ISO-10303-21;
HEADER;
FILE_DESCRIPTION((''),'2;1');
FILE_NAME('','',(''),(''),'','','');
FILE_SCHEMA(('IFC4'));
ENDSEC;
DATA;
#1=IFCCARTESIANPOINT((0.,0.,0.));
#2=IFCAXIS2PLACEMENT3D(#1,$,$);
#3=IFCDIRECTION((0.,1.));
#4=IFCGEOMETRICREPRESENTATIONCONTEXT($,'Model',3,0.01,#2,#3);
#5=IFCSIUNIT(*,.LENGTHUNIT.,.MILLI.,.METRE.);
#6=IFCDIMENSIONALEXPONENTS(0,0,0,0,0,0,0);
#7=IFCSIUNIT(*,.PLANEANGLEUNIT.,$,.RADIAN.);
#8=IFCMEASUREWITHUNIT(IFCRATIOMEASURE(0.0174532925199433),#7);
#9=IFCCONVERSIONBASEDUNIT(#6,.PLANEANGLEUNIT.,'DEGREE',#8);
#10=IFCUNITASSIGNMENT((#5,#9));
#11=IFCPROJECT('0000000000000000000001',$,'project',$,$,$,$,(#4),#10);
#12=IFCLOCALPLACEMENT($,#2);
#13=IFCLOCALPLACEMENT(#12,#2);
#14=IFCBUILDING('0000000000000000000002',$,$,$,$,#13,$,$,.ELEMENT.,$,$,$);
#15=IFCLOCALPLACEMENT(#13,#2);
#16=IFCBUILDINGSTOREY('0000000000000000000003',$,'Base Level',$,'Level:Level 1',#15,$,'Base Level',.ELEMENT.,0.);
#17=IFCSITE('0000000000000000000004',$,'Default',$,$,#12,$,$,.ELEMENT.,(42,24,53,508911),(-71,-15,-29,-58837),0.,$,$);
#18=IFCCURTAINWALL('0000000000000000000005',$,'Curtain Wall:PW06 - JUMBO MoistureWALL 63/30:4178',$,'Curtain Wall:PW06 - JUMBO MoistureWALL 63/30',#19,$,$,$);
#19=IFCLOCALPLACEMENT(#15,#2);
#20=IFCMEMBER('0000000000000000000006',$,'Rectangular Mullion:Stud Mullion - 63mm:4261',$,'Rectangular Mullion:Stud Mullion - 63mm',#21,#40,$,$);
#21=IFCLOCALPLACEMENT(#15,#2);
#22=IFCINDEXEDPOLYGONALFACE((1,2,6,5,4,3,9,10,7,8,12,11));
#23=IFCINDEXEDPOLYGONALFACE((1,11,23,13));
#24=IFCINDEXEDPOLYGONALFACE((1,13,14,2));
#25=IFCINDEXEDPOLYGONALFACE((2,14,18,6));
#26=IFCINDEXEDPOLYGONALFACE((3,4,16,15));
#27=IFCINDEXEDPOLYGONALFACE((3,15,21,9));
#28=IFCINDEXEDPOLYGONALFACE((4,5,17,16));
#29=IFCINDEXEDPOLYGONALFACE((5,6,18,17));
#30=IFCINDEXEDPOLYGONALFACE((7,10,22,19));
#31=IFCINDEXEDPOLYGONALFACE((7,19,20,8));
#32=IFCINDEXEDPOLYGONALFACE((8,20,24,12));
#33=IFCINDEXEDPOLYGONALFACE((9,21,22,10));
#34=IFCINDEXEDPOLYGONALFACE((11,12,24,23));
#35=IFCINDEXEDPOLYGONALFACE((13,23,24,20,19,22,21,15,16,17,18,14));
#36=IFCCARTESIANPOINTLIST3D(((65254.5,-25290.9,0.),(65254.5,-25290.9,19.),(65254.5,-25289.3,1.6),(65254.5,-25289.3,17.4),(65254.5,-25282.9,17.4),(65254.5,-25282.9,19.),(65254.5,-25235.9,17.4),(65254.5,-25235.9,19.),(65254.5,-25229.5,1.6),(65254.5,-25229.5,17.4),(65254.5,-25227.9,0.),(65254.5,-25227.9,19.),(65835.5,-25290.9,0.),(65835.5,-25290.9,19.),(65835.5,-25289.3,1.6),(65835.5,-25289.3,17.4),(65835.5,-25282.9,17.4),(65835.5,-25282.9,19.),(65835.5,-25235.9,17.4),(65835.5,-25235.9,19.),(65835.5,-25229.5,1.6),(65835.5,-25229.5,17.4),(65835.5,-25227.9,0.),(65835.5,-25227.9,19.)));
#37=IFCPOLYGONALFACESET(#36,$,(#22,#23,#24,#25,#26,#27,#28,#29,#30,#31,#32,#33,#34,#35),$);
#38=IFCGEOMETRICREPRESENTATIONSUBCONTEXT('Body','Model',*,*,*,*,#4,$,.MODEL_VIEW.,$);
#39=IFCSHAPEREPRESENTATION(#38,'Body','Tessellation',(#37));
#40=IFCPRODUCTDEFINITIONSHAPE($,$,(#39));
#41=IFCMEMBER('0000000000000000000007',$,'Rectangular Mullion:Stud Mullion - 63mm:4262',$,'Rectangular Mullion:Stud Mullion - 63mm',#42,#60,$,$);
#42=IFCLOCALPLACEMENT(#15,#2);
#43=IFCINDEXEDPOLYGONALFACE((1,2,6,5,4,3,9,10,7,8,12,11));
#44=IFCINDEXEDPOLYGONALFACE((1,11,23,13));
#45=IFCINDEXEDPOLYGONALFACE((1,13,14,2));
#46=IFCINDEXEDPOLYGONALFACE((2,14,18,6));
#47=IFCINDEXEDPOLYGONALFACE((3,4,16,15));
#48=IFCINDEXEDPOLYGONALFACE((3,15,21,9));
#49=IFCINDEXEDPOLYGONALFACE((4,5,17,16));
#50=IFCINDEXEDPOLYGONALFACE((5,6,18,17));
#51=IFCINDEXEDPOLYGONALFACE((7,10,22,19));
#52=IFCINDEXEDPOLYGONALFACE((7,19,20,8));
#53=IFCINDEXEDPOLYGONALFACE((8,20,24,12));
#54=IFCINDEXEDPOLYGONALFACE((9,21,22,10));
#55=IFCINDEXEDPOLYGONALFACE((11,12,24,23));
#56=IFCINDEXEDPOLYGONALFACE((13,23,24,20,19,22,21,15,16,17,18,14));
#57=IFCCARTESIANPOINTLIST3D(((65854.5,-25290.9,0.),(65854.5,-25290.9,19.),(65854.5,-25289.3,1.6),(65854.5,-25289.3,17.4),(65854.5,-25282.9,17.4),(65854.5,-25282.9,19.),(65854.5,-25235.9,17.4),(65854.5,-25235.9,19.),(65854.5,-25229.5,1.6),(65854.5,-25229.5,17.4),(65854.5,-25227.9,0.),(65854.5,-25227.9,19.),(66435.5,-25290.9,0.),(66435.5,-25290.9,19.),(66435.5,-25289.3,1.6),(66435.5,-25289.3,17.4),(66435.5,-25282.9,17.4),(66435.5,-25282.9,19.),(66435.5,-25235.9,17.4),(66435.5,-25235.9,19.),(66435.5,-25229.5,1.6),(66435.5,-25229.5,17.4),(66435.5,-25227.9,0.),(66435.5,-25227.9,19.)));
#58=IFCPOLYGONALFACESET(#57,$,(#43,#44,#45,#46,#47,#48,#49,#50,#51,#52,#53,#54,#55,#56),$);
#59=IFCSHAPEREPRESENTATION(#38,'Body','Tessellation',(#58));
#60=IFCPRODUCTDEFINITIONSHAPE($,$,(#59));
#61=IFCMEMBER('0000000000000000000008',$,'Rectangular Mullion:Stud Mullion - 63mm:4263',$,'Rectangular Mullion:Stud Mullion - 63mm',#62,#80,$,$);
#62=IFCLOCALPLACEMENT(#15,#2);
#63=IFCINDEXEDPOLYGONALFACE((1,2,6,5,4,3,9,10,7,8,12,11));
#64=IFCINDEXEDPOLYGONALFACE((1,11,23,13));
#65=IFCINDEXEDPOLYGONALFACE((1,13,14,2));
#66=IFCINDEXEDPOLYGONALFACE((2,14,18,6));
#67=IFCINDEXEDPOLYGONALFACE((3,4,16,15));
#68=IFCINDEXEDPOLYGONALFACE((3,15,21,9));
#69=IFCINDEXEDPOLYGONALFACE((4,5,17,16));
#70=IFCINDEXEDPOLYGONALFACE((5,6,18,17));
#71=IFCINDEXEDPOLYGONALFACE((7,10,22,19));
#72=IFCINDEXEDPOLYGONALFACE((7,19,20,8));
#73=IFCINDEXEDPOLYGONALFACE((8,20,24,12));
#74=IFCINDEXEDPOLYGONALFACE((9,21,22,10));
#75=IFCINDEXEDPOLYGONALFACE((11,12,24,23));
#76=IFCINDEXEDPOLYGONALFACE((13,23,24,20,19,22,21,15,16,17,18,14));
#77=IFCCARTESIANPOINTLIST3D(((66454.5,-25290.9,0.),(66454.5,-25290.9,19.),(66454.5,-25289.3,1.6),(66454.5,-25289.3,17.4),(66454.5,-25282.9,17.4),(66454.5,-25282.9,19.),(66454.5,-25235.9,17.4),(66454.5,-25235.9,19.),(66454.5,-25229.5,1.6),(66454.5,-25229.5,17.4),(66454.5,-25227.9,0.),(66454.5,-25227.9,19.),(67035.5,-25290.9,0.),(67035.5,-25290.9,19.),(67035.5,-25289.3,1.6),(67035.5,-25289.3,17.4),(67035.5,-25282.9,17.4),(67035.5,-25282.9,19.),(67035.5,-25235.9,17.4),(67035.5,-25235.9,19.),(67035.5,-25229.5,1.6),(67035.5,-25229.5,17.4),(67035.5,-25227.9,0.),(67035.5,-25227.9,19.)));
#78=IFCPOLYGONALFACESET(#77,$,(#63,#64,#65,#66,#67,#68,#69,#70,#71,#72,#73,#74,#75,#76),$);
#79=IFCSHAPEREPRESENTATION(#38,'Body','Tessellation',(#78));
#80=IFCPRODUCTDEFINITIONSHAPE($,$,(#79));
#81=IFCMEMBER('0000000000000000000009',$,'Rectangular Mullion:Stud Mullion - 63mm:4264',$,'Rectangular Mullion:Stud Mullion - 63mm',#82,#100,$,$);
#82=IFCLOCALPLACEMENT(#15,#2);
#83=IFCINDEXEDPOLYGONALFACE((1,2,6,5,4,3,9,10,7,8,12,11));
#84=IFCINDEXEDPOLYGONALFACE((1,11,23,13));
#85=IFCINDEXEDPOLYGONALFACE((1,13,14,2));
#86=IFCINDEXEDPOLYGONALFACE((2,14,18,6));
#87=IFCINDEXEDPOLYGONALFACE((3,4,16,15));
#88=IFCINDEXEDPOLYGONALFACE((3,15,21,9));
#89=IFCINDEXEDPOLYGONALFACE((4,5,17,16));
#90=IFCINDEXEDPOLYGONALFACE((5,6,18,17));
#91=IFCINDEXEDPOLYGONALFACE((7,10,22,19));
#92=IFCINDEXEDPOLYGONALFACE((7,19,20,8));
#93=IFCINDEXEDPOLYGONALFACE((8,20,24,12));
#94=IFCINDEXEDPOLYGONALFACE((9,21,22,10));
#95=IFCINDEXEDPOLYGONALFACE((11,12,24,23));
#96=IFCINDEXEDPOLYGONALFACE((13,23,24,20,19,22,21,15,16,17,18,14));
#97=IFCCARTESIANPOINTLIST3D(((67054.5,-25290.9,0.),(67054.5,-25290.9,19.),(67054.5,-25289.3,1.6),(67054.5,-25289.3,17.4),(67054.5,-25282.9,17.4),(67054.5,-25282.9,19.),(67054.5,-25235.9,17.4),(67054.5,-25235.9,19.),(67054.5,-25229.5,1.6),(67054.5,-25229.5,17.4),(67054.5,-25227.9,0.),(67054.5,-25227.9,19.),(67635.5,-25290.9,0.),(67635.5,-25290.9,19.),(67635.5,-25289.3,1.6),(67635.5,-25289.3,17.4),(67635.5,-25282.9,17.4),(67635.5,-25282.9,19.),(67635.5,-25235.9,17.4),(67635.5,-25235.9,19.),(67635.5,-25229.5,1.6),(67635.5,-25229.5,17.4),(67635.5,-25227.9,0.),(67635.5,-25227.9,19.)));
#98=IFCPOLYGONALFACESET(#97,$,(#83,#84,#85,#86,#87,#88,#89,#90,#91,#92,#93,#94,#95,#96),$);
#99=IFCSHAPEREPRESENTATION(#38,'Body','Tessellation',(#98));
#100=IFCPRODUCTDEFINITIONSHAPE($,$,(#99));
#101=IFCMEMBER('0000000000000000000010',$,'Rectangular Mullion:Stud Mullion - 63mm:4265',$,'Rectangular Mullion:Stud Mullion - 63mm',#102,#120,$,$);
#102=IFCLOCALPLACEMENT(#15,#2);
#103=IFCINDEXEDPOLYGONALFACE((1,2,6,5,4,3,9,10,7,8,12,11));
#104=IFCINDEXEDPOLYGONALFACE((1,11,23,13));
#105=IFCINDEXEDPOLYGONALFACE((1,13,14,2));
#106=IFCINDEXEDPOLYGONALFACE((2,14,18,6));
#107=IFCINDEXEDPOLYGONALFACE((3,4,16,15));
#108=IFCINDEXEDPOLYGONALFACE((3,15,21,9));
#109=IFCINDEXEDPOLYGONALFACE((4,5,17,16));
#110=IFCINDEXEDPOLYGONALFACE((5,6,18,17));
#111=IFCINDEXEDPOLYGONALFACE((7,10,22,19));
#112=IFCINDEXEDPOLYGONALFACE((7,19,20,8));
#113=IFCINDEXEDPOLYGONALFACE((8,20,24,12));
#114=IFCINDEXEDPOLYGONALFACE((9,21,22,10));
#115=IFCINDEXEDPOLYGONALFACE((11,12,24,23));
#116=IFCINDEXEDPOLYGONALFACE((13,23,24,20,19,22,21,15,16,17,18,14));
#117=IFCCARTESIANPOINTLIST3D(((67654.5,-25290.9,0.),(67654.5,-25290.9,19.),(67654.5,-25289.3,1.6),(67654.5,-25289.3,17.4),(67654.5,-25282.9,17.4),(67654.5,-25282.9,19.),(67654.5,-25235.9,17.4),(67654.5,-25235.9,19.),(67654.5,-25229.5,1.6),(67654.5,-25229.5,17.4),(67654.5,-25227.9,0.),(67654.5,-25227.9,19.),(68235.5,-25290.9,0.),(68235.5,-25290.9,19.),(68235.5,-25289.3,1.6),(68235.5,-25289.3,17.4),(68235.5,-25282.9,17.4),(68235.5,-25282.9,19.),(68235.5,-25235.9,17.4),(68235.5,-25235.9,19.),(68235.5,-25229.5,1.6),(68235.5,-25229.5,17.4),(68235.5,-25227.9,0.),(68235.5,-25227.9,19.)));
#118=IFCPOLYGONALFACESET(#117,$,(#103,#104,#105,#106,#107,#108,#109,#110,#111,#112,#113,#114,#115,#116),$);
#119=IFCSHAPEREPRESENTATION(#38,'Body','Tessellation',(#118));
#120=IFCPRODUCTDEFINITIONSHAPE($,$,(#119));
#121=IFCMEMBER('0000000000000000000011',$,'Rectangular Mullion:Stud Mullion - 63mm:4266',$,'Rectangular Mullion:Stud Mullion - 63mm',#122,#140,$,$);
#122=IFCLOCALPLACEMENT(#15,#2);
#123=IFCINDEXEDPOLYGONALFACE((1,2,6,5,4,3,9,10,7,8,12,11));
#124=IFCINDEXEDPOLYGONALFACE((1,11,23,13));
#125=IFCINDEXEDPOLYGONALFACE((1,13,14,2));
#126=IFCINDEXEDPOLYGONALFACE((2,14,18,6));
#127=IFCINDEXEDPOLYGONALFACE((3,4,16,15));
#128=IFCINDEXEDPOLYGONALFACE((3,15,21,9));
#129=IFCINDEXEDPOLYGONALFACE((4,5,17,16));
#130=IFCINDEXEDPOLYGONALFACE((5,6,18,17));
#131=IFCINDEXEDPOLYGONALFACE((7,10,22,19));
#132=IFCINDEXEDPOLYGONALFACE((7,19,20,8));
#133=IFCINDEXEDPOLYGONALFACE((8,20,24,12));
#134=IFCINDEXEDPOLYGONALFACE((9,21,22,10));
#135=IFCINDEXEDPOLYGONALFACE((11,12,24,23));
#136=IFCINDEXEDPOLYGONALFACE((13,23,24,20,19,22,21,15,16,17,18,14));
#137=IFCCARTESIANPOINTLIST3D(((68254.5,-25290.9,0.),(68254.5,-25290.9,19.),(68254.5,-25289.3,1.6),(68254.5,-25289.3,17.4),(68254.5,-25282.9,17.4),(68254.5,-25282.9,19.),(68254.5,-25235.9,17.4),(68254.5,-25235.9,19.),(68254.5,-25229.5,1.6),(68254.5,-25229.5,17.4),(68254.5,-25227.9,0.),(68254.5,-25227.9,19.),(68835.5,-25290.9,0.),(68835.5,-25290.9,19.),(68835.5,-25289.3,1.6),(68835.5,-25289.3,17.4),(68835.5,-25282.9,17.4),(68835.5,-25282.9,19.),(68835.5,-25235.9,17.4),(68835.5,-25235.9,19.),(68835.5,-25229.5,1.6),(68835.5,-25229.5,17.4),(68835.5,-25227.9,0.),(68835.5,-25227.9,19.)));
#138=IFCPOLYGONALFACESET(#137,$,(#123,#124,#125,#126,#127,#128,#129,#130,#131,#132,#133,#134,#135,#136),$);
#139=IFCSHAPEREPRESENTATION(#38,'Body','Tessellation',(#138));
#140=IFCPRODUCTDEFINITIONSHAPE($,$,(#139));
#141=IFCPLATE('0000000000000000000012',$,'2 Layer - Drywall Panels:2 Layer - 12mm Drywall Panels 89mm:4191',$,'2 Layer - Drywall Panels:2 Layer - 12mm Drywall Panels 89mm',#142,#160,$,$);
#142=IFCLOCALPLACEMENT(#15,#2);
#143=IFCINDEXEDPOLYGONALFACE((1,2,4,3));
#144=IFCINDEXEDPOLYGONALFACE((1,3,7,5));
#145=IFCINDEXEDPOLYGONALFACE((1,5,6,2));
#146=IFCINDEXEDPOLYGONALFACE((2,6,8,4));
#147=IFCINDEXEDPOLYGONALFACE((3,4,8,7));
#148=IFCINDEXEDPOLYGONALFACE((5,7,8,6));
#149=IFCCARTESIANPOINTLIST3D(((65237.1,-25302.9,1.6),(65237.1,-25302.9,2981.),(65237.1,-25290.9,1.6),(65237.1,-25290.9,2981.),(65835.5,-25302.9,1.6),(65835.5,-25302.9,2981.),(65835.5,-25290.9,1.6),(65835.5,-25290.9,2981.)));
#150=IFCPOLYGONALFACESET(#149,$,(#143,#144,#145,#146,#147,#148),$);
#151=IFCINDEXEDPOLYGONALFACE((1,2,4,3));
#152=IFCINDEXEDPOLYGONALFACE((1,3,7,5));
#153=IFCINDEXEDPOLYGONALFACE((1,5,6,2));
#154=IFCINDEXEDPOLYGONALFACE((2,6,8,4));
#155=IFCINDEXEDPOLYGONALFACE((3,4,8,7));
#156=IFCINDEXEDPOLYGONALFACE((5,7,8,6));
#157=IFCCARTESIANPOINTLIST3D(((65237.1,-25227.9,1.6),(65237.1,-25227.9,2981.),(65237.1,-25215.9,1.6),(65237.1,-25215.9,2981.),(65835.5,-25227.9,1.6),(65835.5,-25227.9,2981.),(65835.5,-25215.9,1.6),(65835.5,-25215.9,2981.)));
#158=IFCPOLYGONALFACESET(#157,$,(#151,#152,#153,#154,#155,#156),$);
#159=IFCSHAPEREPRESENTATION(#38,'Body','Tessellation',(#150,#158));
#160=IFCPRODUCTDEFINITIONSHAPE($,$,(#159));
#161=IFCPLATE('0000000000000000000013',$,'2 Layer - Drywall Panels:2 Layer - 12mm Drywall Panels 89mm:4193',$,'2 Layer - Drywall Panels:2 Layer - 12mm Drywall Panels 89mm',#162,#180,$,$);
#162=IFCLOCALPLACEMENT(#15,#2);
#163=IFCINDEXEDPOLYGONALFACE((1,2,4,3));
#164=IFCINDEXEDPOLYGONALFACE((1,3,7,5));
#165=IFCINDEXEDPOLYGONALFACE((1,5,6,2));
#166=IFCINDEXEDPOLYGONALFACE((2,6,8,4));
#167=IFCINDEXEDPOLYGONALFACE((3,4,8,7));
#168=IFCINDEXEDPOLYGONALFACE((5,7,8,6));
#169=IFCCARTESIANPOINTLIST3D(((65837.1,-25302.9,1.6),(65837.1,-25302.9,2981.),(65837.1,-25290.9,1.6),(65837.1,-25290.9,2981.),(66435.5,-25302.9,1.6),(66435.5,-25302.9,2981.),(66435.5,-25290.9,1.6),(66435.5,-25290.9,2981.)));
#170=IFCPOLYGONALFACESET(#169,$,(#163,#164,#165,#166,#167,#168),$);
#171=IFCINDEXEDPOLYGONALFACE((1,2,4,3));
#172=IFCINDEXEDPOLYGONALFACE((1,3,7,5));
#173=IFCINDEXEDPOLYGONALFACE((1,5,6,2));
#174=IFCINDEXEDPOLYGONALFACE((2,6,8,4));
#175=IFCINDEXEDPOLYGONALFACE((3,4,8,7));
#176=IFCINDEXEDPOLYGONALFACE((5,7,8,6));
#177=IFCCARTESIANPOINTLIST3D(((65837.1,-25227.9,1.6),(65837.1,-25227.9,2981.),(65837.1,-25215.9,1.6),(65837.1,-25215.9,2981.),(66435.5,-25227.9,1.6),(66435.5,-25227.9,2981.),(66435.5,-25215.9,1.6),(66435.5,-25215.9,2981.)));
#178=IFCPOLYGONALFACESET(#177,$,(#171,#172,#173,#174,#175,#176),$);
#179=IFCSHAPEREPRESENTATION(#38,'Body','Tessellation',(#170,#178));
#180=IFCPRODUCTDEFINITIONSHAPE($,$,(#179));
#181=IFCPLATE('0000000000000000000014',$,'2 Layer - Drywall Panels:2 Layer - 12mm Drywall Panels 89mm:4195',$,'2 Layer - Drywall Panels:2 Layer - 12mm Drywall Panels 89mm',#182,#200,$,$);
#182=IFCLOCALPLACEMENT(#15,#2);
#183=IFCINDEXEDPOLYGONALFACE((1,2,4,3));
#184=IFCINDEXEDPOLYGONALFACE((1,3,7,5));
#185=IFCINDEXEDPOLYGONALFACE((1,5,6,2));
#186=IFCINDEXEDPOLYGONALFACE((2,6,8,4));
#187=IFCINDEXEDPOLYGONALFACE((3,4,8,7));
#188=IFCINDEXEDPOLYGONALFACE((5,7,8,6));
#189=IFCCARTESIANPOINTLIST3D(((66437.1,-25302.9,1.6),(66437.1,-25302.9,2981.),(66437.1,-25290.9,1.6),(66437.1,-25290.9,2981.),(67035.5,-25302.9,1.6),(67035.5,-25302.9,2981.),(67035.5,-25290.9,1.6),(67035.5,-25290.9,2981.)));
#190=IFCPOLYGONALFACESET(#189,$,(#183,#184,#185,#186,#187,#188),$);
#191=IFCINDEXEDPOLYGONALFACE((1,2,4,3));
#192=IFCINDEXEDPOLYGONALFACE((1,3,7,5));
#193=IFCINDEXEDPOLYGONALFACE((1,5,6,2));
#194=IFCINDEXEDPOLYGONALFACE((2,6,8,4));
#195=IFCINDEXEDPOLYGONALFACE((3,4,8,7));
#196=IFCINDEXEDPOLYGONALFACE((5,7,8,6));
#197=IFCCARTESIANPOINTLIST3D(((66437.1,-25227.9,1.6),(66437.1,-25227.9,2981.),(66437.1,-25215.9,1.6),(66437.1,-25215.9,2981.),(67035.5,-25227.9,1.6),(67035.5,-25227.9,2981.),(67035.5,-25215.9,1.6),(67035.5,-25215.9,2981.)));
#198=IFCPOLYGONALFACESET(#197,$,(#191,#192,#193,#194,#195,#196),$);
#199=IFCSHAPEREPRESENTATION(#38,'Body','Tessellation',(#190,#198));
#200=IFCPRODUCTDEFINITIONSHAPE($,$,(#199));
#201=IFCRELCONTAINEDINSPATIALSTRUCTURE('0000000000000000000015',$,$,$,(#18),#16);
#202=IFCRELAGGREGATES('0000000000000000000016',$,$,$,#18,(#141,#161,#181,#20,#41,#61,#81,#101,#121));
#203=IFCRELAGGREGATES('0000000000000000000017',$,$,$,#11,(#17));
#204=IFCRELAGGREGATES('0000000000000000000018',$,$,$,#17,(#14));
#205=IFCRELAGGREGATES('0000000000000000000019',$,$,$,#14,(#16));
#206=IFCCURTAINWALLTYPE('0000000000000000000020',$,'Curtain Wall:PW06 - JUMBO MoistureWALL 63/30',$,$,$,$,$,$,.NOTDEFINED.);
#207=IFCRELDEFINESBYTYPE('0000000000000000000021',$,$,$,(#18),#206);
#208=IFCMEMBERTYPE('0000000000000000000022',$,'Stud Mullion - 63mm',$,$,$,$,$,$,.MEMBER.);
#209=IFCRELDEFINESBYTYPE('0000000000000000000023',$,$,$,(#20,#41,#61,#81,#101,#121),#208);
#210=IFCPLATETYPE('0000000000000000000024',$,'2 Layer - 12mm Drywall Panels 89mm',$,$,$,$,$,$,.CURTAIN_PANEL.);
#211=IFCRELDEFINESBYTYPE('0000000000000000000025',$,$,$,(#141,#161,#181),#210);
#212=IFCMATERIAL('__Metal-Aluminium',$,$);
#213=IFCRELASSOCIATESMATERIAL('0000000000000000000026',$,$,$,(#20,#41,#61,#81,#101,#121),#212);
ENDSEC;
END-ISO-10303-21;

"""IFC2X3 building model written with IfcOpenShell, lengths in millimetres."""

from ifc_helpers import new_model, entity, si_unit, converted_unit, direction, frame, frame_2d, origin, place, context, subcontext, project, spatial, polyline, rectangle, outline, extrude, source, transform, mapped, material, type_object, type_shapes, element, aggregate, save


model = new_model("IFC2X3")

# Units and contexts
model_context = context("Model", 3, precision=0.01, world=origin(), true_north=direction((0.0, 1.0)))
body_context = subcontext(model_context, "Body", "Model", "MODEL_VIEW")
ifc_project = project(units=[si_unit("LENGTHUNIT", "METRE", prefix="MILLI"), converted_unit("PLANEANGLEUNIT", "DEGREE", entity("IfcRatioMeasure", 0.0174532925199433), si_unit("PLANEANGLEUNIT", "RADIAN"), dimensions=[0, 0, 0, 0, 0, 0, 0])], contexts=[model_context])

# Site, building, storey
site_placement = place(None, origin())
site = spatial("IfcSite", under=ifc_project, at=site_placement, Name="Default", CompositionType="ELEMENT", RefLatitude=(42, 24, 53, 508911), RefLongitude=(-71, -15, -29, -58837), RefElevation=0.0)
building_placement = place(site_placement, origin())
building = spatial("IfcBuilding", under=site, at=building_placement, CompositionType="ELEMENT")
storey_placement = place(building_placement, origin())
storey = spatial("IfcBuildingStorey", under=building, at=storey_placement, Name="Base Level", ObjectType="Level:Level 1", LongName="Base Level", CompositionType="ELEMENT", Elevation=0.0)

# Curtain wall, members, plates
curtain_wall_type = type_object("IfcCurtainWallType", Name="Curtain Wall:PW06 - JUMBO MoistureWALL 63/30", PredefinedType="NOTDEFINED")
curtain_wall_placement = place(building_placement, origin())
curtain_wall = element("IfcCurtainWall", 1, at=curtain_wall_placement, inside=storey, type_object=curtain_wall_type, Name="Curtain Wall:PW06 - JUMBO MoistureWALL 63/30:4178", ObjectType="Curtain Wall:PW06 - JUMBO MoistureWALL 63/30")
ifc_material = material(Name="__Metal-Aluminium")
member_type_1 = type_object("IfcMemberType", Name="Stud Mullion - 63mm", PredefinedType="MEMBER")
shared_shape_1 = source(origin(), body_context, "Body", "SweptSolid", [
    extrude(outline(polyline([(23.5, -6.6), (31.5, -6.6), (31.5, 12.4), (-31.5, 12.4), (-31.5, -6.6), (-23.5, -6.6), (-23.5, -5.0), (-29.9, -5.0), (-29.9, 10.8), (29.9, 10.8), (29.9, -5.0), (23.5, -5.0), (23.5, -6.6)])), frame((-12.4, 0.0, -581.0), z_axis=(0.0, 0.0, 1.0), x_axis=(0.0, -1.0, 0.0)), (0.0, 0.0, 1.0), 581.0),
])
type_shapes(member_type_1, [shared_shape_1])
member_1_placement = place(building_placement, frame((65254.5, -25259.4, 0.0), z_axis=(-1.0, 0.0, 0.0), x_axis=(0.0, 0.0, -1.0)))
member_1 = element("IfcMember", 2, at=member_1_placement, type_object=member_type_1, material=ifc_material, Name="Rectangular Mullion:Stud Mullion - 63mm:4261", ObjectType="Rectangular Mullion:Stud Mullion - 63mm", context=body_context, shape_type="MappedRepresentation", body=[
    mapped(shared_shape_1, transform((0.0, 0.0, 0.0), scale=1.0)),
])
member_2_placement = place(building_placement, frame((65854.5, -25259.4, 0.0), z_axis=(-1.0, 0.0, 0.0), x_axis=(0.0, 0.0, -1.0)))
member_2 = element("IfcMember", 3, at=member_2_placement, type_object=member_type_1, material=ifc_material, Name="Rectangular Mullion:Stud Mullion - 63mm:4262", ObjectType="Rectangular Mullion:Stud Mullion - 63mm", context=body_context, shape_type="MappedRepresentation", body=[
    mapped(shared_shape_1, transform((0.0, 0.0, 0.0), scale=1.0)),
])
member_3_placement = place(building_placement, frame((66454.5, -25259.4, 0.0), z_axis=(-1.0, 0.0, 0.0), x_axis=(0.0, 0.0, -1.0)))
member_3 = element("IfcMember", 4, at=member_3_placement, type_object=member_type_1, material=ifc_material, Name="Rectangular Mullion:Stud Mullion - 63mm:4263", ObjectType="Rectangular Mullion:Stud Mullion - 63mm", context=body_context, shape_type="MappedRepresentation", body=[
    mapped(shared_shape_1, transform((0.0, 0.0, 0.0), scale=1.0)),
])
member_4_placement = place(building_placement, frame((67054.5, -25259.4, 0.0), z_axis=(-1.0, 0.0, 0.0), x_axis=(0.0, 0.0, -1.0)))
member_4 = element("IfcMember", 5, at=member_4_placement, type_object=member_type_1, material=ifc_material, Name="Rectangular Mullion:Stud Mullion - 63mm:4264", ObjectType="Rectangular Mullion:Stud Mullion - 63mm", context=body_context, shape_type="MappedRepresentation", body=[
    mapped(shared_shape_1, transform((0.0, 0.0, 0.0), scale=1.0)),
])
member_5_placement = place(building_placement, frame((67654.5, -25259.4, 0.0), z_axis=(-1.0, 0.0, 0.0), x_axis=(0.0, 0.0, -1.0)))
member_5 = element("IfcMember", 6, at=member_5_placement, type_object=member_type_1, material=ifc_material, Name="Rectangular Mullion:Stud Mullion - 63mm:4265", ObjectType="Rectangular Mullion:Stud Mullion - 63mm", context=body_context, shape_type="MappedRepresentation", body=[
    mapped(shared_shape_1, transform((0.0, 0.0, 0.0), scale=1.0)),
])
member_6_placement = place(building_placement, frame((68254.5, -25259.4, 0.0), z_axis=(-1.0, 0.0, 0.0), x_axis=(0.0, 0.0, -1.0)))
member_6 = element("IfcMember", 7, at=member_6_placement, type_object=member_type_1, material=ifc_material, Name="Rectangular Mullion:Stud Mullion - 63mm:4266", ObjectType="Rectangular Mullion:Stud Mullion - 63mm", context=body_context, shape_type="MappedRepresentation", body=[
    mapped(shared_shape_1, transform((0.0, 0.0, 0.0), scale=1.0)),
])
plate_type = type_object("IfcPlateType", Name="2 Layer - 12mm Drywall Panels 89mm", PredefinedType="CURTAIN_PANEL")
shared_shape_2 = source(origin(), body_context, "Body", "SweptSolid", [
    extrude(rectangle(XDim=598.4, YDim=12.0, at=frame_2d((0.0, 0.0), x_axis=(1.0, 0.0))), frame((0.0, -37.5, 0.0), z_axis=(0.0, 0.0, 1.0), x_axis=(-1.0, 0.0, 0.0)), (0.0, 0.0, 1.0), 2979.4),
    extrude(rectangle(XDim=12.0, YDim=598.4, at=frame_2d((0.0, 0.0), x_axis=(1.0, 0.0))), frame((0.0, 37.5, 0.0), z_axis=(0.0, 0.0, 1.0), x_axis=(0.0, 1.0, 0.0)), (0.0, 0.0, 1.0), 2979.4),
])
type_shapes(plate_type, [shared_shape_2])
plate_1_placement = place(curtain_wall_placement, frame((65536.3, -25259.4, 1.6)))
plate_1 = element("IfcPlate", 8, at=plate_1_placement, type_object=plate_type, Name="2 Layer - Drywall Panels:2 Layer - 12mm Drywall Panels 89mm:4191", ObjectType="2 Layer - Drywall Panels:2 Layer - 12mm Drywall Panels 89mm", context=body_context, shape_type="MappedRepresentation", body=[
    mapped(shared_shape_2, transform((0.0, 0.0, 0.0), scale=1.0)),
])
plate_2_placement = place(curtain_wall_placement, frame((66136.3, -25259.4, 1.6)))
plate_2 = element("IfcPlate", 9, at=plate_2_placement, type_object=plate_type, Name="2 Layer - Drywall Panels:2 Layer - 12mm Drywall Panels 89mm:4193", ObjectType="2 Layer - Drywall Panels:2 Layer - 12mm Drywall Panels 89mm", context=body_context, shape_type="MappedRepresentation", body=[
    mapped(shared_shape_2, transform((0.0, 0.0, 0.0), scale=1.0)),
])
plate_3_placement = place(curtain_wall_placement, frame((66736.3, -25259.4, 1.6)))
plate_3 = element("IfcPlate", 10, at=plate_3_placement, type_object=plate_type, Name="2 Layer - Drywall Panels:2 Layer - 12mm Drywall Panels 89mm:4195", ObjectType="2 Layer - Drywall Panels:2 Layer - 12mm Drywall Panels 89mm", context=body_context, shape_type="MappedRepresentation", body=[
    mapped(shared_shape_2, transform((0.0, 0.0, 0.0), scale=1.0)),
])
aggregate(curtain_wall, [plate_1, plate_2, plate_3, member_1, member_2, member_3, member_4, member_5, member_6])

save(model, "model.ifc")
